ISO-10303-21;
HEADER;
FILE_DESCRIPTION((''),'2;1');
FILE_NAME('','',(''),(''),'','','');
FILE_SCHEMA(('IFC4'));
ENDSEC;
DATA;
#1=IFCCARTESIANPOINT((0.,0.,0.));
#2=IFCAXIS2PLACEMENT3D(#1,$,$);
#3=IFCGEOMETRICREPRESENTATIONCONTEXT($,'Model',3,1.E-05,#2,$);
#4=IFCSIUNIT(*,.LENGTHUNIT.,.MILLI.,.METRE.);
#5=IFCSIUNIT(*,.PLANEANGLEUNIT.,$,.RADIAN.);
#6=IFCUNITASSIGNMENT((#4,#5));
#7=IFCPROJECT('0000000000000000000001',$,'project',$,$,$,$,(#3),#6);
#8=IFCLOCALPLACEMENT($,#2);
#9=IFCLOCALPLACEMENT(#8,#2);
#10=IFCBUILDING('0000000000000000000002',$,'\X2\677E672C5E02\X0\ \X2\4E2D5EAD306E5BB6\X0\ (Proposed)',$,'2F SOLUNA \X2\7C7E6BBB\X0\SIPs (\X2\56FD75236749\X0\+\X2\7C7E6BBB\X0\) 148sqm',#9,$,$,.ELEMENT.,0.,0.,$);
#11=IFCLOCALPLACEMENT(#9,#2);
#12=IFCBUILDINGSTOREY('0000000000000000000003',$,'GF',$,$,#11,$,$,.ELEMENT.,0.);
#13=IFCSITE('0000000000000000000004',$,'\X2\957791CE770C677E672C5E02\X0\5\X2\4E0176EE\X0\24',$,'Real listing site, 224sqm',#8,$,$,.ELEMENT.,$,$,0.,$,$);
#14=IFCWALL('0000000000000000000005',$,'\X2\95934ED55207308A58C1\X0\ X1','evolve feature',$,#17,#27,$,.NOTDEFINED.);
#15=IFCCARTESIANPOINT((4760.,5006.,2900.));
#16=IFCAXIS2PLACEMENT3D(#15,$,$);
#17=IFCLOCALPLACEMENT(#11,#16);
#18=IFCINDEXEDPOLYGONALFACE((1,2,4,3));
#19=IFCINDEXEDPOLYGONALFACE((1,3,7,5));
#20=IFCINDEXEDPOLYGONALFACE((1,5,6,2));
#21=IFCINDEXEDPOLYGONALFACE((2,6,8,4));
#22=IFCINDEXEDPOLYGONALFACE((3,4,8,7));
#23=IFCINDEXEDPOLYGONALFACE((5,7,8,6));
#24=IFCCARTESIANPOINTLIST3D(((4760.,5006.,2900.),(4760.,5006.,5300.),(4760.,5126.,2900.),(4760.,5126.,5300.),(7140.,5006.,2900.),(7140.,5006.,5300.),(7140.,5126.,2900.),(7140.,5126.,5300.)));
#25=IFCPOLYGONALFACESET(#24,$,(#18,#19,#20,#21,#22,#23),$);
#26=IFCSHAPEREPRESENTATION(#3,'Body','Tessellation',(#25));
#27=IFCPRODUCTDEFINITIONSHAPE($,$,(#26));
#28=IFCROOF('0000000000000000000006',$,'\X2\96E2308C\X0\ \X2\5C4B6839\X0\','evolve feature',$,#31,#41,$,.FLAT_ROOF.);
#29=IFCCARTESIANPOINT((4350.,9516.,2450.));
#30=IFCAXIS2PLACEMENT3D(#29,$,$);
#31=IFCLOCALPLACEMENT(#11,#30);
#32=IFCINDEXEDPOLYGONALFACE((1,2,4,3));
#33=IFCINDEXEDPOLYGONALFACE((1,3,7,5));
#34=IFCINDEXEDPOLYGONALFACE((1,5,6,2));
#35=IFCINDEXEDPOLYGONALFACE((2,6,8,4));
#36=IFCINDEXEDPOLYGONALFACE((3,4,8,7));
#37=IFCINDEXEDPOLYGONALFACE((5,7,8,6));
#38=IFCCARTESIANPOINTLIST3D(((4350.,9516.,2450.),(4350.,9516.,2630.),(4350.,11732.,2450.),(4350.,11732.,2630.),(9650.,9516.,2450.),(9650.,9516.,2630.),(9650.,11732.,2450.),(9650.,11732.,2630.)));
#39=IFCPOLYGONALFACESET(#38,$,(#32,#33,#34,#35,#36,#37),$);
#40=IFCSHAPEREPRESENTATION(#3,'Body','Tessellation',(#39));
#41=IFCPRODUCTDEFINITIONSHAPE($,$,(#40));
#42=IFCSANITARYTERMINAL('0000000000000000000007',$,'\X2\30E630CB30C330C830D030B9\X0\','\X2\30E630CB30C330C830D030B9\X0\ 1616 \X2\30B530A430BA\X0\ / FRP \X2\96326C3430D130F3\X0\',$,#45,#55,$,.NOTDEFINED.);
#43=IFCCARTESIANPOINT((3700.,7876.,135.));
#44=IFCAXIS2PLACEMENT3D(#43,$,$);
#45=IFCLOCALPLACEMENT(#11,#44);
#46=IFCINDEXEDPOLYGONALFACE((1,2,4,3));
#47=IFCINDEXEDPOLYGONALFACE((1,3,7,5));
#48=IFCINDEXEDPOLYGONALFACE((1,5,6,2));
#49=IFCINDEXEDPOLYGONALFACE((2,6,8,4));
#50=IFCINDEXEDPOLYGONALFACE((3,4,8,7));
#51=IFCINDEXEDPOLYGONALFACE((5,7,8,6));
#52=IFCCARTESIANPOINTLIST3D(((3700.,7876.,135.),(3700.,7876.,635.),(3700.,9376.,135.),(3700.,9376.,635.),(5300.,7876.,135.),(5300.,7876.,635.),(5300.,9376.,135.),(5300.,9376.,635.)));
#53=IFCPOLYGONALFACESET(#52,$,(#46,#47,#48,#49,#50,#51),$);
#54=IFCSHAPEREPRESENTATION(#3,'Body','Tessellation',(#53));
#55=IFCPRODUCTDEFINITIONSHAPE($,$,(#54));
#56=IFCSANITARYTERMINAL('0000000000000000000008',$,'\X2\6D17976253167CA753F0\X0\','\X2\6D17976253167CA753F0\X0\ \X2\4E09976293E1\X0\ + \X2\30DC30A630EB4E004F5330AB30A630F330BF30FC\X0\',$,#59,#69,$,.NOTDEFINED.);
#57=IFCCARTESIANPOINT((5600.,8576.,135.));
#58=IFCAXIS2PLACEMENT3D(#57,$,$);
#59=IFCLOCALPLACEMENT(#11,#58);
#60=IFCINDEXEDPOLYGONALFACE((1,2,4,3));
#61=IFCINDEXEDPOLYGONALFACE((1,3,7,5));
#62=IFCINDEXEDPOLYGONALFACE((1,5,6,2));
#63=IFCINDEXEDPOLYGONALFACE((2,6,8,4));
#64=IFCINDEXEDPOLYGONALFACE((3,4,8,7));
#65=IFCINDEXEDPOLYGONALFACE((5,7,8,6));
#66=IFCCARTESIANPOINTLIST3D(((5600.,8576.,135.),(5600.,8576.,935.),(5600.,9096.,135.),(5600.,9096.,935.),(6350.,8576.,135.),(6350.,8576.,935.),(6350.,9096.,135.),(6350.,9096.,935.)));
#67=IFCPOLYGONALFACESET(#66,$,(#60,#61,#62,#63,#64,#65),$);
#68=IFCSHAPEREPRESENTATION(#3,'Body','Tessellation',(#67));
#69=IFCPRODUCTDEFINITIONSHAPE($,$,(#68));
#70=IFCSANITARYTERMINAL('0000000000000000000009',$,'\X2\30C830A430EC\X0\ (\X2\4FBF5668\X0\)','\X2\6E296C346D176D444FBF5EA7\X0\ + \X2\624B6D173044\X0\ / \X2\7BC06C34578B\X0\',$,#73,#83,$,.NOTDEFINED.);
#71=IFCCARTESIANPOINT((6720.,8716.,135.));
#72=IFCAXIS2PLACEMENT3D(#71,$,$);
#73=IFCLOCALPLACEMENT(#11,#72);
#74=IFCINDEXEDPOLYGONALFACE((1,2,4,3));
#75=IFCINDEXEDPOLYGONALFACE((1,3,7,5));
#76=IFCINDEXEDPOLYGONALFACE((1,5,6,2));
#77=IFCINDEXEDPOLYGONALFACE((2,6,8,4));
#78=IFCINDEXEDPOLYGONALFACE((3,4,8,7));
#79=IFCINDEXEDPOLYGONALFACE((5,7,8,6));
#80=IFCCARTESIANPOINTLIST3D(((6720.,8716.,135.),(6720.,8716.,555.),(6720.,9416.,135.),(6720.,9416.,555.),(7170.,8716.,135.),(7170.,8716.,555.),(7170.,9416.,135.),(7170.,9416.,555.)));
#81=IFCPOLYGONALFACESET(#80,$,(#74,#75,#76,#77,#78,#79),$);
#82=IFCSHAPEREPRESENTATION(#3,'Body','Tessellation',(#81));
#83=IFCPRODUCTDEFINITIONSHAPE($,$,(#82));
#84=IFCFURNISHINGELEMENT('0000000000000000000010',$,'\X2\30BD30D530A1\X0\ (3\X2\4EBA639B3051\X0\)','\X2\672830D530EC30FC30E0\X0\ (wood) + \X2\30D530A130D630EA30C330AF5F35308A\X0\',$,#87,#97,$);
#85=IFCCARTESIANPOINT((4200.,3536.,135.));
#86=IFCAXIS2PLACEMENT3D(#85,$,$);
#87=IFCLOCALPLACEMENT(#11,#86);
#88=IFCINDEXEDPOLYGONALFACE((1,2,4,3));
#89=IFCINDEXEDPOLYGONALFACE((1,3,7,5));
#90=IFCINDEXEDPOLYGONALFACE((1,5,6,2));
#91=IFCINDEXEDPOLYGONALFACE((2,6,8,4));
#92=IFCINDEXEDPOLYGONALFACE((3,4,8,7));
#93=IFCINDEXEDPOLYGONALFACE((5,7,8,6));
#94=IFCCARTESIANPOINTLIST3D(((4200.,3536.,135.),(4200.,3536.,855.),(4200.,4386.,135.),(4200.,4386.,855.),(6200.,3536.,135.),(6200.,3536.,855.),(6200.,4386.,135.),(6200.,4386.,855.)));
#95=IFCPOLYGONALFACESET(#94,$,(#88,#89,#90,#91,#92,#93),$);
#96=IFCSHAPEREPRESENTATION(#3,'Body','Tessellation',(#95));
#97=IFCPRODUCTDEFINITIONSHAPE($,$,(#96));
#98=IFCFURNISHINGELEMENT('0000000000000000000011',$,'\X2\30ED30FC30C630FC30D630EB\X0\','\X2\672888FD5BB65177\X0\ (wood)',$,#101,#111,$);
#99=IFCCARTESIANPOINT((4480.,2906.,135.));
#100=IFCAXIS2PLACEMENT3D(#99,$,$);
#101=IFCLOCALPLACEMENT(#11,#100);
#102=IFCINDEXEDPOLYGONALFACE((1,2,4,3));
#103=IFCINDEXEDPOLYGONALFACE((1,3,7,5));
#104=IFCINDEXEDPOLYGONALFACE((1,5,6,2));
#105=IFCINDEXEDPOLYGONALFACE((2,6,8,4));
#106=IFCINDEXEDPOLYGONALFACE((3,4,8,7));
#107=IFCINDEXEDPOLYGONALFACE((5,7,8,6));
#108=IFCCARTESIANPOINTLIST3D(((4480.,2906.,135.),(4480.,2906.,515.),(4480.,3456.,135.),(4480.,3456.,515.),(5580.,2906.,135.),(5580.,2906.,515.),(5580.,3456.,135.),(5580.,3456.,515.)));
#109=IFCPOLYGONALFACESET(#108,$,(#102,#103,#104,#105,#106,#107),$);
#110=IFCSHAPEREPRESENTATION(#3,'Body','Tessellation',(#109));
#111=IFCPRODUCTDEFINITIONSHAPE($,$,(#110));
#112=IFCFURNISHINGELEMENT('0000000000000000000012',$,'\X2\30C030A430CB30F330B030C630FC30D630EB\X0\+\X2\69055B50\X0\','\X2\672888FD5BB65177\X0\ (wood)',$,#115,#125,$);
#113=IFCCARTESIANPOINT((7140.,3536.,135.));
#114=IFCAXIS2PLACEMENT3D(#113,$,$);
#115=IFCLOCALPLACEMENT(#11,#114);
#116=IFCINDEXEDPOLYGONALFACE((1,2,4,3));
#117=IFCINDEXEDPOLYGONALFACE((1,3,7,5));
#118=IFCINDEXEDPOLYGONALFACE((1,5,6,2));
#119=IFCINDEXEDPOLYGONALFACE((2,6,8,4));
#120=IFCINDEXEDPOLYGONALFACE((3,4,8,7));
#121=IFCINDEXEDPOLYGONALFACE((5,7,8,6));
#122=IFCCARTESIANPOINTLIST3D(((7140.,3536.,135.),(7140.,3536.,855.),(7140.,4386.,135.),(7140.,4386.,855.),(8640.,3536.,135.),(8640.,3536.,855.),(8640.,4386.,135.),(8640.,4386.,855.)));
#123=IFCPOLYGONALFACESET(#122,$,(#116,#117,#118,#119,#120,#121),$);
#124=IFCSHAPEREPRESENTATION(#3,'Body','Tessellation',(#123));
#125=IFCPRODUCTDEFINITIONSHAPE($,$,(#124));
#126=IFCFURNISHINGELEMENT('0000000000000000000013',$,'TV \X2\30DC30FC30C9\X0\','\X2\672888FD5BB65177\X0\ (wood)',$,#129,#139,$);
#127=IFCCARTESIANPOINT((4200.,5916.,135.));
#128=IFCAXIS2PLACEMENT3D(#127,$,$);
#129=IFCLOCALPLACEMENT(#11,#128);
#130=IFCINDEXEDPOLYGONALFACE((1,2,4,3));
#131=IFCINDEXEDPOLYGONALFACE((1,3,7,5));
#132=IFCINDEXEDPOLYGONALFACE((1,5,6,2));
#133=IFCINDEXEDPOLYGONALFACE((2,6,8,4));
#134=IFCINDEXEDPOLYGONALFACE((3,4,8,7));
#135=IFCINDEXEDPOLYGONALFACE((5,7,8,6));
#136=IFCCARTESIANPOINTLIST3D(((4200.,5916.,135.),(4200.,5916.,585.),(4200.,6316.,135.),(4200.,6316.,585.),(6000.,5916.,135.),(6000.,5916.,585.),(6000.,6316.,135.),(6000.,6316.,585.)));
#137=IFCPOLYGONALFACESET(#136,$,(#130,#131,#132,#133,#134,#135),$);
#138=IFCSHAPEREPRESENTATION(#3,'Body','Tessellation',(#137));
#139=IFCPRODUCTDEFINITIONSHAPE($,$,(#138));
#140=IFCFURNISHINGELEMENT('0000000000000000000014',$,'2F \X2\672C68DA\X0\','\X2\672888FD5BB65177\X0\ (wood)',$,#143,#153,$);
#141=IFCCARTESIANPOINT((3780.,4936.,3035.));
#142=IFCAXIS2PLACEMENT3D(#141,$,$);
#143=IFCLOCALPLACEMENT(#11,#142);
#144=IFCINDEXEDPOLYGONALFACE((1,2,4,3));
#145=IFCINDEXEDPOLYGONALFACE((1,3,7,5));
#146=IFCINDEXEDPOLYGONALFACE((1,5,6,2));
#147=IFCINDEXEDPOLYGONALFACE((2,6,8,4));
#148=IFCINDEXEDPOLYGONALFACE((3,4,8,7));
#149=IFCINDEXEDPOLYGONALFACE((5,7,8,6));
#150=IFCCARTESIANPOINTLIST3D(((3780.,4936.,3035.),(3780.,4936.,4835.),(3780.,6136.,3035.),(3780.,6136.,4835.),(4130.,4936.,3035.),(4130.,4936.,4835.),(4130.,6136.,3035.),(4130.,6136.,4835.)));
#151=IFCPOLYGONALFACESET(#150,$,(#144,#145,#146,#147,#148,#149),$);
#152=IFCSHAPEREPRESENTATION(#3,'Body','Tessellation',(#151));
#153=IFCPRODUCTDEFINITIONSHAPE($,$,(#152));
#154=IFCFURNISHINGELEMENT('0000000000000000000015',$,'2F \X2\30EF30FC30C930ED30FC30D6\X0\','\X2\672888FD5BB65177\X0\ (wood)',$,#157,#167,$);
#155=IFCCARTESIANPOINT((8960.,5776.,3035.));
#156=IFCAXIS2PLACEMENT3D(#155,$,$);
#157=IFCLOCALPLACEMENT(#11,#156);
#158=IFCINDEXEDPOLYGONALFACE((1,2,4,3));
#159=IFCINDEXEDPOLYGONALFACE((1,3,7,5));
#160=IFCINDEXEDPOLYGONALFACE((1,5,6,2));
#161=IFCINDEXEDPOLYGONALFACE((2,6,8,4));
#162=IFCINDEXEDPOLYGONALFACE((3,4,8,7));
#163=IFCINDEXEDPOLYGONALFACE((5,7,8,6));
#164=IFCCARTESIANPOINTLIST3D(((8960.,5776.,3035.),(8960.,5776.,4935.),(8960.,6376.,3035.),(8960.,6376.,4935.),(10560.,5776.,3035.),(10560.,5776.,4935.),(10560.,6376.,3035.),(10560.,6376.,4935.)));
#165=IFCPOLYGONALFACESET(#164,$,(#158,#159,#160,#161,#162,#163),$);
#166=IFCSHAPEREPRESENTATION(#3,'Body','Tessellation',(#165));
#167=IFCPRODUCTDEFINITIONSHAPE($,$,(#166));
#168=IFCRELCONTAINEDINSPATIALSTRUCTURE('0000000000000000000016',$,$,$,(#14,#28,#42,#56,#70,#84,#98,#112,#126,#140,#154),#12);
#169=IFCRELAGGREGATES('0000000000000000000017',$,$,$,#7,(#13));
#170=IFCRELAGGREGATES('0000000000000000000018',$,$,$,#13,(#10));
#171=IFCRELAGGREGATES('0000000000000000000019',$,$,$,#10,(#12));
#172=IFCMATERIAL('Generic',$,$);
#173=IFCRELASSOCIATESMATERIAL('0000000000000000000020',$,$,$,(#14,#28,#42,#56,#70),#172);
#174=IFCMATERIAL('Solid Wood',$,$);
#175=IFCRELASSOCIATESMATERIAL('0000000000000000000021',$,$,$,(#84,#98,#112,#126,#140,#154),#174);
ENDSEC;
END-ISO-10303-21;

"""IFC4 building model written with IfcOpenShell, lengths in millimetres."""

from ifc_helpers import new_model, si_unit, frame, frame_2d, origin, place, context, project, spatial, rectangle, extrude, material, element, save


model = new_model("IFC4")

# Units and contexts
model_context = context("Model", 3, precision=1e-05, world=origin())
ifc_project = project(units=[si_unit("LENGTHUNIT", "METRE", prefix="MILLI"), si_unit("PLANEANGLEUNIT", "RADIAN")], contexts=[model_context])

# Site, building, storey
site_placement = place(None, origin())
site = spatial("IfcSite", under=ifc_project, at=site_placement, Name="長野県松本市5丁目24", ObjectType="Real listing site, 224sqm", CompositionType="ELEMENT", RefElevation=0.0)
building_placement = place(site_placement, origin())
building = spatial("IfcBuilding", under=site, at=building_placement, Name="松本市 中庭の家 (Proposed)", ObjectType="2F SOLUNA 籾殻SIPs (国産杉+籾殻) 148sqm", CompositionType="ELEMENT", ElevationOfRefHeight=0.0, ElevationOfTerrain=0.0)
storey_placement = place(building_placement, origin())
storey = spatial("IfcBuildingStorey", under=building, at=storey_placement, Name="GF", CompositionType="ELEMENT", Elevation=0.0)

# Shared definitions
ifc_material_1 = material(Name="Generic")

# Shared definitions
ifc_material_2 = material(Name="Solid Wood")

# Wall
wall_1_placement = place(storey_placement, frame((4760.0, 5006.0, 2900.0)))
element("IfcWall", 1, at=wall_1_placement, inside=storey, material=ifc_material_1, Name="間仕切り壁 X1", Description="evolve feature", PredefinedType="NOTDEFINED", context=model_context, shape_type="SweptSolid", body=[
    extrude(rectangle(XDim=2380.0, YDim=120.0, at=frame_2d((1190.0, 60.0))), frame((4760.0, 5006.0, 2900.0)), (0.0, 0.0, 1.0), 2400.0),
])

# Roof
roof_placement = place(storey_placement, frame((4350.0, 9516.0, 2450.0)))
element("IfcRoof", 2, at=roof_placement, inside=storey, material=ifc_material_1, Name="離れ 屋根", Description="evolve feature", PredefinedType="FLAT_ROOF", context=model_context, shape_type="SweptSolid", body=[
    extrude(rectangle(XDim=5300.0, YDim=2216.0, at=frame_2d((2650.0, 1108.0))), frame((4350.0, 9516.0, 2450.0)), (0.0, 0.0, 1.0), 180.0),
])

# Sanitary terminals
sanitary_terminal_1_placement = place(storey_placement, frame((3700.0, 7876.0, 135.0)))
element("IfcSanitaryTerminal", 3, at=sanitary_terminal_1_placement, inside=storey, material=ifc_material_1, Name="ユニットバス", Description="ユニットバス 1616 サイズ / FRP 防水パン", PredefinedType="NOTDEFINED", context=model_context, shape_type="SweptSolid", body=[
    extrude(rectangle(XDim=1600.0, YDim=1500.0, at=frame_2d((800.0, 750.0))), frame((3700.0, 7876.0, 135.0)), (0.0, 0.0, 1.0), 500.0),
])
sanitary_terminal_2_placement = place(storey_placement, frame((5600.0, 8576.0, 135.0)))
element("IfcSanitaryTerminal", 4, at=sanitary_terminal_2_placement, inside=storey, material=ifc_material_1, Name="洗面化粧台", Description="洗面化粧台 三面鏡 + ボウル一体カウンター", PredefinedType="NOTDEFINED", context=model_context, shape_type="SweptSolid", body=[
    extrude(rectangle(XDim=750.0, YDim=520.0, at=frame_2d((375.0, 260.0))), frame((5600.0, 8576.0, 135.0)), (0.0, 0.0, 1.0), 800.0),
])
sanitary_terminal_3_placement = place(storey_placement, frame((6720.0, 8716.0, 135.0)))
element("IfcSanitaryTerminal", 5, at=sanitary_terminal_3_placement, inside=storey, material=ifc_material_1, Name="トイレ (便器)", Description="温水洗浄便座 + 手洗い / 節水型", PredefinedType="NOTDEFINED", context=model_context, shape_type="SweptSolid", body=[
    extrude(rectangle(XDim=450.0, YDim=700.0, at=frame_2d((225.0, 350.0))), frame((6720.0, 8716.0, 135.0)), (0.0, 0.0, 1.0), 420.0),
])

# Furnishing elements
furnishing_1_placement = place(storey_placement, frame((4200.0, 3536.0, 135.0)))
element("IfcFurnishingElement", 6, at=furnishing_1_placement, inside=storey, material=ifc_material_2, Name="ソファ (3人掛け)", Description="木フレーム (wood) + ファブリック張り", context=model_context, shape_type="SweptSolid", body=[
    extrude(rectangle(XDim=2000.0, YDim=850.0, at=frame_2d((1000.0, 425.0))), frame((4200.0, 3536.0, 135.0)), (0.0, 0.0, 1.0), 720.0),
])
furnishing_2_placement = place(storey_placement, frame((4480.0, 2906.0, 135.0)))
element("IfcFurnishingElement", 7, at=furnishing_2_placement, inside=storey, material=ifc_material_2, Name="ローテーブル", Description="木製家具 (wood)", context=model_context, shape_type="SweptSolid", body=[
    extrude(rectangle(XDim=1100.0, YDim=550.0, at=frame_2d((550.0, 275.0))), frame((4480.0, 2906.0, 135.0)), (0.0, 0.0, 1.0), 380.0),
])
furnishing_3_placement = place(storey_placement, frame((7140.0, 3536.0, 135.0)))
element("IfcFurnishingElement", 8, at=furnishing_3_placement, inside=storey, material=ifc_material_2, Name="ダイニングテーブル+椅子", Description="木製家具 (wood)", context=model_context, shape_type="SweptSolid", body=[
    extrude(rectangle(XDim=1500.0, YDim=850.0, at=frame_2d((750.0, 425.0))), frame((7140.0, 3536.0, 135.0)), (0.0, 0.0, 1.0), 720.0),
])
furnishing_4_placement = place(storey_placement, frame((4200.0, 5916.0, 135.0)))
element("IfcFurnishingElement", 9, at=furnishing_4_placement, inside=storey, material=ifc_material_2, Name="TV ボード", Description="木製家具 (wood)", context=model_context, shape_type="SweptSolid", body=[
    extrude(rectangle(XDim=1800.0, YDim=400.0, at=frame_2d((900.0, 200.0))), frame((4200.0, 5916.0, 135.0)), (0.0, 0.0, 1.0), 450.0),
])
furnishing_5_placement = place(storey_placement, frame((3780.0, 4936.0, 3035.0)))
element("IfcFurnishingElement", 10, at=furnishing_5_placement, inside=storey, material=ifc_material_2, Name="2F 本棚", Description="木製家具 (wood)", context=model_context, shape_type="SweptSolid", body=[
    extrude(rectangle(XDim=350.0, YDim=1200.0, at=frame_2d((175.0, 600.0))), frame((3780.0, 4936.0, 3035.0)), (0.0, 0.0, 1.0), 1800.0),
])
furnishing_6_placement = place(storey_placement, frame((8960.0, 5776.0, 3035.0)))
element("IfcFurnishingElement", 11, at=furnishing_6_placement, inside=storey, material=ifc_material_2, Name="2F ワードローブ", Description="木製家具 (wood)", context=model_context, shape_type="SweptSolid", body=[
    extrude(rectangle(XDim=1600.0, YDim=600.0, at=frame_2d((800.0, 300.0))), frame((8960.0, 5776.0, 3035.0)), (0.0, 0.0, 1.0), 1900.0),
])

save(model, "model.ifc")
